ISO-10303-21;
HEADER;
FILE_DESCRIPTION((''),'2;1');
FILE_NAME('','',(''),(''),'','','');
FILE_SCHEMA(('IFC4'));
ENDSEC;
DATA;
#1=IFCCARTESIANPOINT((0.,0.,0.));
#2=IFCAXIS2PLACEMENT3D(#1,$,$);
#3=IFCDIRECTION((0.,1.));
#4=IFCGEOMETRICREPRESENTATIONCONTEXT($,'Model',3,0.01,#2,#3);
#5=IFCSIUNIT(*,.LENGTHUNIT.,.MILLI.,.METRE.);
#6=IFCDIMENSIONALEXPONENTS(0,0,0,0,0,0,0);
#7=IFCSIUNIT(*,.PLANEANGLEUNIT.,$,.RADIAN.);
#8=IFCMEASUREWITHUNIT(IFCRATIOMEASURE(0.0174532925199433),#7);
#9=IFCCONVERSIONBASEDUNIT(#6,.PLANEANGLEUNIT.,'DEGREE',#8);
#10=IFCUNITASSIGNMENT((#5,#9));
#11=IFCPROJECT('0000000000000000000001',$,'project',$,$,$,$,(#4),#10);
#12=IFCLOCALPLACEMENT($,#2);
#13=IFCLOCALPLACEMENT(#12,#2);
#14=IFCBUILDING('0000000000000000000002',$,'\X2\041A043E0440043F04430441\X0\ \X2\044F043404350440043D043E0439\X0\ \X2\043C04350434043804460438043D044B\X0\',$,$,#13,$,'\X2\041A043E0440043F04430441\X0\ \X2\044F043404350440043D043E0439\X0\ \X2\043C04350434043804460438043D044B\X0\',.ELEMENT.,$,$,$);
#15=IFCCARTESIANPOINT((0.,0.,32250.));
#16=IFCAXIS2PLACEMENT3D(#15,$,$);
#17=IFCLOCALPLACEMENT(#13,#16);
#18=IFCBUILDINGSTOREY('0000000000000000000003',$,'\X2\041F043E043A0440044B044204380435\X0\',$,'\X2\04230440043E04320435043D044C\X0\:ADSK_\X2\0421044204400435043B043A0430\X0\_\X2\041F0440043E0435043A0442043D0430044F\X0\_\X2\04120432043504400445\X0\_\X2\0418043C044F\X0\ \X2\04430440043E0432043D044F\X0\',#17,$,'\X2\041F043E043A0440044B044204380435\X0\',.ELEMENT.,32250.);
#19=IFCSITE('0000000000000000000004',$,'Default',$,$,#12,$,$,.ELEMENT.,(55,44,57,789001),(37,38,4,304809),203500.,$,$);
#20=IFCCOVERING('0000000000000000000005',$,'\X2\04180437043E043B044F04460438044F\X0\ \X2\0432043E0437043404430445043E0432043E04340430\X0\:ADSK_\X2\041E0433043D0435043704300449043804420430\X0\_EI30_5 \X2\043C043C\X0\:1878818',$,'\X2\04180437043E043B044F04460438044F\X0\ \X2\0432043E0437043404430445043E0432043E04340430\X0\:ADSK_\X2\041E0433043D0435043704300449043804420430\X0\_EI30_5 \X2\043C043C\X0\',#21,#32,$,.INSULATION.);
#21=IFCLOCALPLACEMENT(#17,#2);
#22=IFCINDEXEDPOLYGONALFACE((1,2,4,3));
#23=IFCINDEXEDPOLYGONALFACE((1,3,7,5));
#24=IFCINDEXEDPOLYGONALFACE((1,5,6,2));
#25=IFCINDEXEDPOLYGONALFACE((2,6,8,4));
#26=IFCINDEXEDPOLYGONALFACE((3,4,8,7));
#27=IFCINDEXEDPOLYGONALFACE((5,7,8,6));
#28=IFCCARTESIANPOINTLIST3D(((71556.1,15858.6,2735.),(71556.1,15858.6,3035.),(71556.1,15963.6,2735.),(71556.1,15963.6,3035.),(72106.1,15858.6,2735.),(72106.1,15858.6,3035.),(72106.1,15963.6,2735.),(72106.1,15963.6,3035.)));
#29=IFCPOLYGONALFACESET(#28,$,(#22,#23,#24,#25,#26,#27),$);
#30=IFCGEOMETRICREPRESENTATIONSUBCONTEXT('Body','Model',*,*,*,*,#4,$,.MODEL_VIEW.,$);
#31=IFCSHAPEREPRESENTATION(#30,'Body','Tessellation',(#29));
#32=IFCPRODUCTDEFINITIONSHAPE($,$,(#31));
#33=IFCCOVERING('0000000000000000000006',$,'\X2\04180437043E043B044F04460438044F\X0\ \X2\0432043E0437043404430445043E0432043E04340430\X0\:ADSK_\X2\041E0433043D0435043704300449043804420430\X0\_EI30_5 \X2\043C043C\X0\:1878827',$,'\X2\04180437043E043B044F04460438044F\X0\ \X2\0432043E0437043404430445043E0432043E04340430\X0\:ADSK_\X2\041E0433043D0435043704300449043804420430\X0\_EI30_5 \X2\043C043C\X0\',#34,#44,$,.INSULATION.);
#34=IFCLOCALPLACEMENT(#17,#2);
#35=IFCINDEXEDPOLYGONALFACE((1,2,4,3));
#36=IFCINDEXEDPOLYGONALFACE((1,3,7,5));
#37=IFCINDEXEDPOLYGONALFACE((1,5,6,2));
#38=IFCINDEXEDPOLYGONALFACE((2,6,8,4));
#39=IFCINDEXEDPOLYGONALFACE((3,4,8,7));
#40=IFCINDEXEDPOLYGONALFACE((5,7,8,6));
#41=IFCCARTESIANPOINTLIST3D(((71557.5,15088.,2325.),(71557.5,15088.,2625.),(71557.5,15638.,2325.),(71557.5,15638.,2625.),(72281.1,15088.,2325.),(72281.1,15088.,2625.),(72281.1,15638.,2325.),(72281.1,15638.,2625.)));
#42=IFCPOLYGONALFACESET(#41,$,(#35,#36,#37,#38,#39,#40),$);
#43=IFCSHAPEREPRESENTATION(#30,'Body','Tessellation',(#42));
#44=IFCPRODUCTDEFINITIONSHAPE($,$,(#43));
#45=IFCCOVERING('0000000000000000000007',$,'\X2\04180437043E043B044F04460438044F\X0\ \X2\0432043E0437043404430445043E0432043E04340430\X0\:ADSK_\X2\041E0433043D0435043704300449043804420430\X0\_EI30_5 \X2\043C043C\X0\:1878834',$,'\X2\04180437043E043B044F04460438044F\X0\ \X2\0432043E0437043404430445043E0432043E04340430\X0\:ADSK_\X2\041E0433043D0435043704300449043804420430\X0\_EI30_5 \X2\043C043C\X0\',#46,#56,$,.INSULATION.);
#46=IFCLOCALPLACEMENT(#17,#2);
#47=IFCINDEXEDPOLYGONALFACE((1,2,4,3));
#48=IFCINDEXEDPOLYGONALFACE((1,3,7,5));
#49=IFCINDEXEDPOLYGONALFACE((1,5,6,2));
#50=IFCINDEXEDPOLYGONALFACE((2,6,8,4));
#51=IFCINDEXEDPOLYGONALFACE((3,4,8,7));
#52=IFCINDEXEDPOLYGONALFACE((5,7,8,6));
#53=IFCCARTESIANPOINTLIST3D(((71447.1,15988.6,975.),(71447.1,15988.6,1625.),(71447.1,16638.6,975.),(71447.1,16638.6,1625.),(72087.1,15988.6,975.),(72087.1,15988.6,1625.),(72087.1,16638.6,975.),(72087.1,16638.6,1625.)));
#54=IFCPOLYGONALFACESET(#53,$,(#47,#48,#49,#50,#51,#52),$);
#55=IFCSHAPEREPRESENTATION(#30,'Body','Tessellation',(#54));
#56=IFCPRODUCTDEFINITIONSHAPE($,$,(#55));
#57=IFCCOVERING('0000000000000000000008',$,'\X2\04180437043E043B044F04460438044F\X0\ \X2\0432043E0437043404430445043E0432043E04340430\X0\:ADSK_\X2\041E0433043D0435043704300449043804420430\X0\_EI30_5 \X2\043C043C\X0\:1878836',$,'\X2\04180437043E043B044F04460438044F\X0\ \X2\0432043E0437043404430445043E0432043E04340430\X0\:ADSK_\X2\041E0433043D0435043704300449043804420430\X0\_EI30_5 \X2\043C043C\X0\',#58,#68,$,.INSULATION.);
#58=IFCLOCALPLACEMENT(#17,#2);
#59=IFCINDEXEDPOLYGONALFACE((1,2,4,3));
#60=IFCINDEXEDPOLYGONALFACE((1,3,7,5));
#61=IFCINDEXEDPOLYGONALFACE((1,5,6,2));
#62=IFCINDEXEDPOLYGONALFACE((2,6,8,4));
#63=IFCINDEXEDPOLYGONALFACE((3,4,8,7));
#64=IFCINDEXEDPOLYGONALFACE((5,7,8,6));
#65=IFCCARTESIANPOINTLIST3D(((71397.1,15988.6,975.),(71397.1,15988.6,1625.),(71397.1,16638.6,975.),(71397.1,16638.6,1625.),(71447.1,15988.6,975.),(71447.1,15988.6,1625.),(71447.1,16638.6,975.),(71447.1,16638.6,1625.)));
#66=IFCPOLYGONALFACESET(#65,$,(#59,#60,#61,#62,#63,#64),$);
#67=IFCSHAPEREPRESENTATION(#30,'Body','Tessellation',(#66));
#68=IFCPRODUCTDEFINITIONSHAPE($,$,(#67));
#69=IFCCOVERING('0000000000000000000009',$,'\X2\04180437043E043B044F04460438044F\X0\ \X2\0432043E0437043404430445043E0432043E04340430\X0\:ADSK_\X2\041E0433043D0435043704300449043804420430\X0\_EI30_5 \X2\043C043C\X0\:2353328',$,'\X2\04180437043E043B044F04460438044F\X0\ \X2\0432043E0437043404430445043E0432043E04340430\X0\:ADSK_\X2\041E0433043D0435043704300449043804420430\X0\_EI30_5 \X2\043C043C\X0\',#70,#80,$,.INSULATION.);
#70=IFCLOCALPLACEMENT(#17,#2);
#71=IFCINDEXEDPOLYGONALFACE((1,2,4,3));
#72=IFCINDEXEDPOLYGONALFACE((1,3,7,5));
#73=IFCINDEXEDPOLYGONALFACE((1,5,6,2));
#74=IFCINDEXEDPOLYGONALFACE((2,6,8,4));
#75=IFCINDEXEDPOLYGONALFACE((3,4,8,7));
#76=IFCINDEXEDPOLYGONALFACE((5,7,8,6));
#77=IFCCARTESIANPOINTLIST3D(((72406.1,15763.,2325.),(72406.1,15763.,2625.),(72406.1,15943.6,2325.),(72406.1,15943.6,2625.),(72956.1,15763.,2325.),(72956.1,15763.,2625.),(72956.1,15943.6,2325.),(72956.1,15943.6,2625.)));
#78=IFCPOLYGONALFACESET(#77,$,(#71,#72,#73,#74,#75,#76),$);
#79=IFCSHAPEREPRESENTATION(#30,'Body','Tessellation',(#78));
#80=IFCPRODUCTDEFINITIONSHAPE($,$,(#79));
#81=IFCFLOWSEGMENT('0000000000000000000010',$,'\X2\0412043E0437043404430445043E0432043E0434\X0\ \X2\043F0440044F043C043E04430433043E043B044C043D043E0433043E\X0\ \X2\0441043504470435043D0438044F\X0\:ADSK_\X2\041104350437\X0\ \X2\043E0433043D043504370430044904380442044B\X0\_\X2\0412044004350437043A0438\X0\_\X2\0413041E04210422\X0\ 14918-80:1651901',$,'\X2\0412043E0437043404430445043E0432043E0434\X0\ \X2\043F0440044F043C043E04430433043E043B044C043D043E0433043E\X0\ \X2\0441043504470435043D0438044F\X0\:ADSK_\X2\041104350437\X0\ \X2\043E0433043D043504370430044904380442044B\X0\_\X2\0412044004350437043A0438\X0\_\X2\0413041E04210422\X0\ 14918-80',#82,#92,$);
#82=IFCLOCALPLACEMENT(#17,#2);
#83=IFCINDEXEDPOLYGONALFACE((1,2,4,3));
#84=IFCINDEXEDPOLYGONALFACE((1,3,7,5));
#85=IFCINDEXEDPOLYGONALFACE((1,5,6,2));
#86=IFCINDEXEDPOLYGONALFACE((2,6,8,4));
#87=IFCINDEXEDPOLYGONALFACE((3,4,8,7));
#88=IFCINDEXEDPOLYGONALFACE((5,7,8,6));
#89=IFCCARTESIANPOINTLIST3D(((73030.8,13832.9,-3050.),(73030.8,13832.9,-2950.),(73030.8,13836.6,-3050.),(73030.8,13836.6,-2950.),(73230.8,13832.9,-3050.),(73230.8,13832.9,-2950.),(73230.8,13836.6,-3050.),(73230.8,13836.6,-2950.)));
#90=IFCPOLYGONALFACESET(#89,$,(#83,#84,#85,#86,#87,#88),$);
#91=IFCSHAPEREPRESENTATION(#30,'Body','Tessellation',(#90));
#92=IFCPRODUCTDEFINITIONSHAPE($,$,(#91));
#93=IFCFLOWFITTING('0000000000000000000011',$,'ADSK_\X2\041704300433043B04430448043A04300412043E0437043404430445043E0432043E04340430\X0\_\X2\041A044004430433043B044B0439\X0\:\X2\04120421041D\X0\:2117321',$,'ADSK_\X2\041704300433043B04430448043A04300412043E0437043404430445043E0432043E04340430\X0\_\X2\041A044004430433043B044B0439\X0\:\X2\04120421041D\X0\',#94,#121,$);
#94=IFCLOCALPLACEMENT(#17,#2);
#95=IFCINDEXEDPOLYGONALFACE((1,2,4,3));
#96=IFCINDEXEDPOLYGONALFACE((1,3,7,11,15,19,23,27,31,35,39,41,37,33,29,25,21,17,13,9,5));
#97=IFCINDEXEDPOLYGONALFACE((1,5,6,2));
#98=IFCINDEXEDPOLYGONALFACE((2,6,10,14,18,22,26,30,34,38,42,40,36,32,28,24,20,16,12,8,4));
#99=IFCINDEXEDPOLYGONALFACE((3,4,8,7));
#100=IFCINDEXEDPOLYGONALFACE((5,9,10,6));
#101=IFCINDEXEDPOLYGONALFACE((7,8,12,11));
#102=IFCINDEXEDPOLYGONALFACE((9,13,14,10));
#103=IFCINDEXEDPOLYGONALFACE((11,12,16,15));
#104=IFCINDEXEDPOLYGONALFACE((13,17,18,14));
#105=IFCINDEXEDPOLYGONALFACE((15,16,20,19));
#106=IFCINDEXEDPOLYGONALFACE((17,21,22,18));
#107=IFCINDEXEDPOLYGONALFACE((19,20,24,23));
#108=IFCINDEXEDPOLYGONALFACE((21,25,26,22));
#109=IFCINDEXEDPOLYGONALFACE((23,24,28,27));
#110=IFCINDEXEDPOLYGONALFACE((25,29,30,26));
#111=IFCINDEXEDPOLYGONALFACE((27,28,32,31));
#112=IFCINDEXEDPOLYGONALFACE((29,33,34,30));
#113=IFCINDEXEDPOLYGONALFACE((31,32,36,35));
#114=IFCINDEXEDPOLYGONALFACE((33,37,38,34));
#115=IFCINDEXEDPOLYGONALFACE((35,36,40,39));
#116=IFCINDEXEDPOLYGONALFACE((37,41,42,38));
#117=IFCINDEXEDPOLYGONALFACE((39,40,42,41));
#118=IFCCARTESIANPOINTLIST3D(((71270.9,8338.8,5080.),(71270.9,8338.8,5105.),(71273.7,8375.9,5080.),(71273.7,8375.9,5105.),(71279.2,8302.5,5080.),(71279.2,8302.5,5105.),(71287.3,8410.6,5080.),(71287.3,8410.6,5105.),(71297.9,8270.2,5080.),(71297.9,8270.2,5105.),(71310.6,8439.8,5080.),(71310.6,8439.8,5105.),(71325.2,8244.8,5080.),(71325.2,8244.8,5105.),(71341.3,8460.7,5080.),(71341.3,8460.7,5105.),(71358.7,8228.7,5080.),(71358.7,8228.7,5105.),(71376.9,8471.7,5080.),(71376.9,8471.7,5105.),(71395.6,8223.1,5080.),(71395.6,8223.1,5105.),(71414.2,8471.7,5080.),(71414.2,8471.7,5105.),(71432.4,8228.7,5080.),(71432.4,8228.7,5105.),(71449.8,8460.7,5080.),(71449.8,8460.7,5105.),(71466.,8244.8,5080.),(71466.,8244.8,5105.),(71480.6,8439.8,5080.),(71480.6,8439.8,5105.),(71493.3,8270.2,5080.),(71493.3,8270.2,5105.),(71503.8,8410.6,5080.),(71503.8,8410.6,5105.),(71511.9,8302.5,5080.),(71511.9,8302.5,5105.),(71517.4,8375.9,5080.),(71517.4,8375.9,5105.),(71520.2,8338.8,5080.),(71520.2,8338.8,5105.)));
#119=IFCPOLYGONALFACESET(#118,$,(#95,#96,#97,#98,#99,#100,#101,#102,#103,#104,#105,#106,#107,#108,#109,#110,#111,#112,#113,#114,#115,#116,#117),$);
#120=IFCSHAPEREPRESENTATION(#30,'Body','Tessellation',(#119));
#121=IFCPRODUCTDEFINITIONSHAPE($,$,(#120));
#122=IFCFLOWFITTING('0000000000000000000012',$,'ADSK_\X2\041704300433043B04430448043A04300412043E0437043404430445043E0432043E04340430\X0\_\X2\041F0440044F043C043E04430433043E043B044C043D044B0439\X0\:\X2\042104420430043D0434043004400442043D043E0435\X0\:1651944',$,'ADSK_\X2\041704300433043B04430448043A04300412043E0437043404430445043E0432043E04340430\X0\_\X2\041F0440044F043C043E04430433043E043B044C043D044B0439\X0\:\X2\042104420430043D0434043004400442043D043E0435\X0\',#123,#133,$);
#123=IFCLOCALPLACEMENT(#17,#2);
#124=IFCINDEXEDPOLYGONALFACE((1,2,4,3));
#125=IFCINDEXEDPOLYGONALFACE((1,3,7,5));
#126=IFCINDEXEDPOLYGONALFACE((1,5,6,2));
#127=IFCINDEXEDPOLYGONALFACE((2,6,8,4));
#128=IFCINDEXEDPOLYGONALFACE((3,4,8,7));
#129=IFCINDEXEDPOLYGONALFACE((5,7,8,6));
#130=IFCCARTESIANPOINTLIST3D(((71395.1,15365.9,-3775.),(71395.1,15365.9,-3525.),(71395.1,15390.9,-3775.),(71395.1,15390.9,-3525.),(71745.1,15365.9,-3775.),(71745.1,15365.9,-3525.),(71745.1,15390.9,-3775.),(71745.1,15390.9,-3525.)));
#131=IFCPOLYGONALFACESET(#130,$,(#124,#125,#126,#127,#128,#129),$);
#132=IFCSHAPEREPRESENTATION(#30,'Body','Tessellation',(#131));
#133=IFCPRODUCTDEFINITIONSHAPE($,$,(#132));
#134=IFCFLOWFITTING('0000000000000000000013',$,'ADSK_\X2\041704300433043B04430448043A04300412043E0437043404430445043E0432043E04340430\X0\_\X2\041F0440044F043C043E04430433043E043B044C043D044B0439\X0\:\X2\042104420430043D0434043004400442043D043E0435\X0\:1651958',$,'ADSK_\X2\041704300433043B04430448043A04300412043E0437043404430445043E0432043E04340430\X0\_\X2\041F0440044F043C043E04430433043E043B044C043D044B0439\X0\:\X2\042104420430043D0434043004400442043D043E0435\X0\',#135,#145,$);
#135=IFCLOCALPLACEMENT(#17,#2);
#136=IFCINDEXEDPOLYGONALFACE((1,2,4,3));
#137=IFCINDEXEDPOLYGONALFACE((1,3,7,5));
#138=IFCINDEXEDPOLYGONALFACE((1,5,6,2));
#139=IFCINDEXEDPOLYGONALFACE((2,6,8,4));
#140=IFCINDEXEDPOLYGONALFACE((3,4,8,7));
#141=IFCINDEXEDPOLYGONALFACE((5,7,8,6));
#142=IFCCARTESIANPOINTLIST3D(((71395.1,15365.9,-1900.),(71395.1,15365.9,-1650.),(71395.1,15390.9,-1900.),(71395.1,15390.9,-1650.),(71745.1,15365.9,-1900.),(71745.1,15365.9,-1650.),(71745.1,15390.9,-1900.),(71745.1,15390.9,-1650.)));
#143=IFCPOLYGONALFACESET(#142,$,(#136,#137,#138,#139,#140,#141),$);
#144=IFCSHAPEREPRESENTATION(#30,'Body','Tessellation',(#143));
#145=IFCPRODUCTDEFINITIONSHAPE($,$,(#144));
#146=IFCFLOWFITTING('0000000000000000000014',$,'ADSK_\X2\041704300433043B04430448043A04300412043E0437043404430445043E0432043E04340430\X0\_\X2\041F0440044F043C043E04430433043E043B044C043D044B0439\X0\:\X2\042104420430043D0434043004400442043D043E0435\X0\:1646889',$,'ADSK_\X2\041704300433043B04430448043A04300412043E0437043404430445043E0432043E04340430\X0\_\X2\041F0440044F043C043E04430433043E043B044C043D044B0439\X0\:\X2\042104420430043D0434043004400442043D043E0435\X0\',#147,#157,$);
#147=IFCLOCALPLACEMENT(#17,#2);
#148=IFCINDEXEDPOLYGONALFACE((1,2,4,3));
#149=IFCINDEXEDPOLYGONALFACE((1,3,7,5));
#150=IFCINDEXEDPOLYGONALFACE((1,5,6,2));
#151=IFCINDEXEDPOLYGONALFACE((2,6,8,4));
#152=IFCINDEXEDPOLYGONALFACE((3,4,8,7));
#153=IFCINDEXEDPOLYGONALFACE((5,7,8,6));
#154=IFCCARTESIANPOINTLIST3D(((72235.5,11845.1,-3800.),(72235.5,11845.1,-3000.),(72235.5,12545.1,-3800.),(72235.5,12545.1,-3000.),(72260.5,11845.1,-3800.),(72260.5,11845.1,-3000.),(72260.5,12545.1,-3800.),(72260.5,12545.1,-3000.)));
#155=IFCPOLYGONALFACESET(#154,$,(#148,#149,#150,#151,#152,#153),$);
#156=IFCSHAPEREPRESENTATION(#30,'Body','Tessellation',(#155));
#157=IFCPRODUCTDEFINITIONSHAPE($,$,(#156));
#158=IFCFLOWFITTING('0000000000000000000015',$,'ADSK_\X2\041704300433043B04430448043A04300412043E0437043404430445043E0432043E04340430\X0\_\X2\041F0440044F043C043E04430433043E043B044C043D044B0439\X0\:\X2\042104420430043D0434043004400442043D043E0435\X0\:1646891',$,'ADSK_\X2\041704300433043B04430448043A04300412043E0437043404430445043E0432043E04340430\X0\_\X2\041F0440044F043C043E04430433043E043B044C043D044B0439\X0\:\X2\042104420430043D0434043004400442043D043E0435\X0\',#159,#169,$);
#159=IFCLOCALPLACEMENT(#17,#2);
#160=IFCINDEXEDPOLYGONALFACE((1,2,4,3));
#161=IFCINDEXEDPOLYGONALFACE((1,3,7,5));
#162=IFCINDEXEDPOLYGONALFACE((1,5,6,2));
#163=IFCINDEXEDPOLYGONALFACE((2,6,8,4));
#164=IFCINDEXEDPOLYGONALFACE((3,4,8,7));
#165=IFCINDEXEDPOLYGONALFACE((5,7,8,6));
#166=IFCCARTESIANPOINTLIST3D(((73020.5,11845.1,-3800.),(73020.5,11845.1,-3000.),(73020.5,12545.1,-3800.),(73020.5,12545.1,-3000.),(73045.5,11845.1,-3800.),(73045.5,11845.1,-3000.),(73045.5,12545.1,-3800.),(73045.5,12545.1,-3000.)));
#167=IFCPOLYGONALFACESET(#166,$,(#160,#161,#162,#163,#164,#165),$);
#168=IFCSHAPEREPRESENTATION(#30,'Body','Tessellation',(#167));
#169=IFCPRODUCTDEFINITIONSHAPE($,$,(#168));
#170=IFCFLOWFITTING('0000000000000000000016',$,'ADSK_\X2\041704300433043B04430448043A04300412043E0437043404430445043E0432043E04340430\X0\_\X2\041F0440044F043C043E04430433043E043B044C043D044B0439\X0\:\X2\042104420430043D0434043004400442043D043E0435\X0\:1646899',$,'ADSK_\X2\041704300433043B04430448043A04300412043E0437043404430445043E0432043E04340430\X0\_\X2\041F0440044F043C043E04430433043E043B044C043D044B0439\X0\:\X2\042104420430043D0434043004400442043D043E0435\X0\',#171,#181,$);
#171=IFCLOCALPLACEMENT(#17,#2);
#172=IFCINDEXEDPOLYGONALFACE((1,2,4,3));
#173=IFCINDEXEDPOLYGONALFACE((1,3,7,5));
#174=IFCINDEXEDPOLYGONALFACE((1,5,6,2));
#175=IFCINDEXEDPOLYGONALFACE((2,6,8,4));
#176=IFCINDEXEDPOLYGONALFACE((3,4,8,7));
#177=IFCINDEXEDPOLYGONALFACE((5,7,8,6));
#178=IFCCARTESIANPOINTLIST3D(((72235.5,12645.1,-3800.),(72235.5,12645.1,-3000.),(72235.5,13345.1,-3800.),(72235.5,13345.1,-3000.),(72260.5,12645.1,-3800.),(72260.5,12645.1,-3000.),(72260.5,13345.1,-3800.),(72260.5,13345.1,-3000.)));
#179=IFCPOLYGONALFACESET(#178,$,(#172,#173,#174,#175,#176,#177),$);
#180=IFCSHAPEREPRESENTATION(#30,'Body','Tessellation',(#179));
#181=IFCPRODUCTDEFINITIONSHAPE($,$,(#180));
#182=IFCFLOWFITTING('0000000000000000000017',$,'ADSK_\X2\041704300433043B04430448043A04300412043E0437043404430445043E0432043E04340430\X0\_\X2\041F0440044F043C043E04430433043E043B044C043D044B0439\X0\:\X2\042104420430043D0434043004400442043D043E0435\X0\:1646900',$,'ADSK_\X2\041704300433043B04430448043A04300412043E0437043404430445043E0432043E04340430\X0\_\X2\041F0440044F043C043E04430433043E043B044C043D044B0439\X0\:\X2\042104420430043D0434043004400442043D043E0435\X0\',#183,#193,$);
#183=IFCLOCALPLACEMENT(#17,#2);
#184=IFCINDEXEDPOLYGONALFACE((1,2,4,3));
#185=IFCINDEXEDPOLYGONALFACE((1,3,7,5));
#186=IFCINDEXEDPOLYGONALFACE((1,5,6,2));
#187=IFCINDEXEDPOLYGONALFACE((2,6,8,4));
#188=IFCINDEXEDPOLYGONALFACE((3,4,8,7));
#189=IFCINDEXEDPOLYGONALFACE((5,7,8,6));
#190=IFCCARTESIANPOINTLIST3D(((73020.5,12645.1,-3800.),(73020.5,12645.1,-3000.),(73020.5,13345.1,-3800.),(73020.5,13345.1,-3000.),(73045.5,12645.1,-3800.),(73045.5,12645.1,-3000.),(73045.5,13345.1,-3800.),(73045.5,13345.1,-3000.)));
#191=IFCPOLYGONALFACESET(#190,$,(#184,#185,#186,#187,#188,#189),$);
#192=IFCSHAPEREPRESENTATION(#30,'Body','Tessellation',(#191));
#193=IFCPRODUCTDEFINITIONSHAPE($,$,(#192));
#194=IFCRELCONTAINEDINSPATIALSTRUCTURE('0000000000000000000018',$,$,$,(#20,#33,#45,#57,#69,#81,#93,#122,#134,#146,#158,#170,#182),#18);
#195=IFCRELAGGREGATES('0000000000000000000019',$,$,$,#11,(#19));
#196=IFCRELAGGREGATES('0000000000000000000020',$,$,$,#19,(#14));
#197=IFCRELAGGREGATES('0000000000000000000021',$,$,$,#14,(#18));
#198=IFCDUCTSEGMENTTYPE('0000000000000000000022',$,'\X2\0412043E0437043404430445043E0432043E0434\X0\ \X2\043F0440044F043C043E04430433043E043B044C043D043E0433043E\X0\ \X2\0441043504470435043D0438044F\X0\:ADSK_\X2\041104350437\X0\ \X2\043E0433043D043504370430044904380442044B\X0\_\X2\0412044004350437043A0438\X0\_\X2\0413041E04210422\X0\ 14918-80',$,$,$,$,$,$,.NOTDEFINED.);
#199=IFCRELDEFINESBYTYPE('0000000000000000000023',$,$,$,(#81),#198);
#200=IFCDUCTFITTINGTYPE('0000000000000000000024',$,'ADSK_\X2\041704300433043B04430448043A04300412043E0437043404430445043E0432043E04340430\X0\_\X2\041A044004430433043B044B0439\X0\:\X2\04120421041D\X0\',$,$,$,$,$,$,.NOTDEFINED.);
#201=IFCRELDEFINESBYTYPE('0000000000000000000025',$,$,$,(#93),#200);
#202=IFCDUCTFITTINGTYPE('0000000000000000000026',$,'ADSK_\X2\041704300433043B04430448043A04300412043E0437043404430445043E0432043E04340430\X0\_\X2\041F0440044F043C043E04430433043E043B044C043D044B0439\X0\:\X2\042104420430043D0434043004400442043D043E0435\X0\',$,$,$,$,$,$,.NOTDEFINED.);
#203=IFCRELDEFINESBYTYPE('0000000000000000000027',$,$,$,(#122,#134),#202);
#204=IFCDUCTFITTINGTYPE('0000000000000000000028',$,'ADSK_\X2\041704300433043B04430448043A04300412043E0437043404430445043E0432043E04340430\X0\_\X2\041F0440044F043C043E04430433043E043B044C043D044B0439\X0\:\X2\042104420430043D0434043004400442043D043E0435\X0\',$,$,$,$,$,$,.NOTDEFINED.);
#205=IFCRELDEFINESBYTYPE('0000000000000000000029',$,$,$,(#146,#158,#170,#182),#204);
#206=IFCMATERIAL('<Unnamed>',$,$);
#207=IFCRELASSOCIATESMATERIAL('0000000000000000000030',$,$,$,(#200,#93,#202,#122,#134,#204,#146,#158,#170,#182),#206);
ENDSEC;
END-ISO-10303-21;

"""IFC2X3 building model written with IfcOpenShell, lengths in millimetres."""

from ifc_helpers import new_model, entity, si_unit, converted_unit, direction, frame, origin, origin_2d_with_axis, place, context, subcontext, project, spatial, rectangle, circle, extrude, source, transform, mapped, material, type_object, type_shapes, element, save


model = new_model("IFC2X3")

# Units and contexts
model_context = context("Model", 3, precision=0.01, world=origin(), true_north=direction((0.0, 1.0)))
body_context = subcontext(model_context, "Body", "Model", "MODEL_VIEW")
ifc_project = project(units=[si_unit("LENGTHUNIT", "METRE", prefix="MILLI"), converted_unit("PLANEANGLEUNIT", "DEGREE", entity("IfcRatioMeasure", 0.0174532925199433), si_unit("PLANEANGLEUNIT", "RADIAN"), dimensions=[0, 0, 0, 0, 0, 0, 0])], contexts=[model_context])

# Site, building, storey
site_placement = place(None, origin())
site = spatial("IfcSite", under=ifc_project, at=site_placement, Name="Default", CompositionType="ELEMENT", RefLatitude=(55, 44, 57, 789001), RefLongitude=(37, 38, 4, 304809), RefElevation=203500.0)
building_placement = place(site_placement, origin())
building = spatial("IfcBuilding", under=site, at=building_placement, Name="Корпус ядерной медицины", LongName="Корпус ядерной медицины", CompositionType="ELEMENT")
storey_placement = place(building_placement, frame((0.0, 0.0, 32250.0)))
storey = spatial("IfcBuildingStorey", under=building, at=storey_placement, Name="Покрытие", ObjectType="Уровень:ADSK_Стрелка_Проектная_Вверх_Имя уровня", LongName="Покрытие", CompositionType="ELEMENT", Elevation=32250.0)

# Coverings
covering_1_placement = place(storey_placement, frame((71556.1, 15858.6, 2735.0)))
element("IfcCovering", 1, at=covering_1_placement, inside=storey, Name="Изоляция воздуховода:ADSK_Огнезащита_EI30_5 мм:1878818", ObjectType="Изоляция воздуховода:ADSK_Огнезащита_EI30_5 мм", PredefinedType="INSULATION", context=body_context, shape_type="SweptSolid", body=[
    extrude(rectangle(XDim=105.0, YDim=550.0, at=origin_2d_with_axis()), frame((275.0, 52.5, 0.0), z_axis=(0.0, 0.0, 1.0), x_axis=(0.0, 1.0, 0.0)), (0.0, 0.0, 1.0), 300.0),
])
covering_2_placement = place(storey_placement, frame((71557.5, 15088.0, 2325.0)))
element("IfcCovering", 2, at=covering_2_placement, inside=storey, Name="Изоляция воздуховода:ADSK_Огнезащита_EI30_5 мм:1878827", ObjectType="Изоляция воздуховода:ADSK_Огнезащита_EI30_5 мм", PredefinedType="INSULATION", context=body_context, shape_type="SweptSolid", body=[
    extrude(rectangle(XDim=723.6, YDim=550.0, at=origin_2d_with_axis()), frame((361.8, 275.0, 0.0), z_axis=(0.0, 0.0, 1.0), x_axis=(-1.0, 0.0, 0.0)), (0.0, 0.0, 1.0), 300.0),
])
covering_3_placement = place(storey_placement, frame((71447.1, 15988.6, 975.0)))
element("IfcCovering", 3, at=covering_3_placement, inside=storey, Name="Изоляция воздуховода:ADSK_Огнезащита_EI30_5 мм:1878834", ObjectType="Изоляция воздуховода:ADSK_Огнезащита_EI30_5 мм", PredefinedType="INSULATION", context=body_context, shape_type="SweptSolid", body=[
    extrude(rectangle(XDim=640.0, YDim=650.0, at=origin_2d_with_axis()), frame((320.0, 325.0, 0.0)), (0.0, 0.0, 1.0), 650.0),
])
covering_4_placement = place(storey_placement, frame((71397.1, 15988.6, 975.0)))
element("IfcCovering", 4, at=covering_4_placement, inside=storey, Name="Изоляция воздуховода:ADSK_Огнезащита_EI30_5 мм:1878836", ObjectType="Изоляция воздуховода:ADSK_Огнезащита_EI30_5 мм", PredefinedType="INSULATION", context=body_context, shape_type="SweptSolid", body=[
    extrude(rectangle(XDim=50.0, YDim=650.0, at=origin_2d_with_axis()), frame((25.0, 325.0, 0.0)), (0.0, 0.0, 1.0), 650.0),
])
covering_5_placement = place(storey_placement, frame((72406.1, 15763.0, 2325.0)))
element("IfcCovering", 5, at=covering_5_placement, inside=storey, Name="Изоляция воздуховода:ADSK_Огнезащита_EI30_5 мм:2353328", ObjectType="Изоляция воздуховода:ADSK_Огнезащита_EI30_5 мм", PredefinedType="INSULATION", context=body_context, shape_type="SweptSolid", body=[
    extrude(rectangle(XDim=180.6, YDim=550.0, at=origin_2d_with_axis()), frame((275.0, 90.3, 0.0), z_axis=(0.0, 0.0, 1.0), x_axis=(0.0, 1.0, 0.0)), (0.0, 0.0, 1.0), 300.0),
])

# Flow segment
duct_segment_type = type_object("IfcDuctSegmentType", Name="Воздуховод прямоугольного сечения:ADSK_Без огнезащиты_Врезки_ГОСТ 14918-80", PredefinedType="NOTDEFINED")
flow_segment_placement = place(storey_placement, frame((73030.8, 13832.9, -3050.0)))
element("IfcFlowSegment", 6, at=flow_segment_placement, inside=storey, type_object=duct_segment_type, Name="Воздуховод прямоугольного сечения:ADSK_Без огнезащиты_Врезки_ГОСТ 14918-80:1651901", ObjectType="Воздуховод прямоугольного сечения:ADSK_Без огнезащиты_Врезки_ГОСТ 14918-80", context=body_context, shape_type="SweptSolid", body=[
    extrude(rectangle(XDim=3.8, YDim=200.0, at=origin_2d_with_axis()), frame((100.0, 1.9, 0.0), z_axis=(0.0, 0.0, 1.0), x_axis=(0.0, -1.0, 0.0)), (0.0, 0.0, 1.0), 100.0),
])

# Flow fittings
ifc_material = material(Name="<Unnamed>")
duct_fitting_type_1 = type_object("IfcDuctFittingType", Name="ADSK_ЗаглушкаВоздуховода_Круглый:ВСН", PredefinedType="NOTDEFINED", material=ifc_material)
shared_shape_1 = source(origin(), body_context, "Body", "SweptSolid", [
    extrude(circle(Radius=125.0, at=origin_2d_with_axis()), frame((0.0, 0.0, 0.0), z_axis=(1.0, 0.0, 0.0), x_axis=(0.0, 1.0, 0.0)), (0.0, 0.0, 1.0), 25.0),
])
type_shapes(duct_fitting_type_1, [shared_shape_1])
flow_fitting_1_placement = place(storey_placement, frame((71395.6, 8348.1, 5080.0), z_axis=(1.0, 0.0, 0.0), x_axis=(0.0, 0.0, 1.0)))
element("IfcFlowFitting", 7, at=flow_fitting_1_placement, inside=storey, type_object=duct_fitting_type_1, material=ifc_material, Name="ADSK_ЗаглушкаВоздуховода_Круглый:ВСН:2117321", ObjectType="ADSK_ЗаглушкаВоздуховода_Круглый:ВСН", context=body_context, shape_type="MappedRepresentation", body=[
    mapped(shared_shape_1, transform((0.0, 0.0, 0.0), scale=1.0)),
])
duct_fitting_type_2 = type_object("IfcDuctFittingType", Name="ADSK_ЗаглушкаВоздуховода_Прямоугольный:Стандартное", PredefinedType="NOTDEFINED", material=ifc_material)
shared_shape_2 = source(origin(), body_context, "Body", "SweptSolid", [
    extrude(rectangle(XDim=25.0, YDim=350.0, at=origin_2d_with_axis()), frame((12.5, 0.0, -125.0)), (0.0, 0.0, 1.0), 250.0),
])
type_shapes(duct_fitting_type_2, [shared_shape_2])
for number, where, z_axis, x_axis, name in (
    (8, (71570.1, 15390.9, -3650.0), (0.0, 0.0, 1.0), (0.0, -1.0, 0.0), "ADSK_ЗаглушкаВоздуховода_Прямоугольный:Стандартное:1651944"),
    (9, (71570.1, 15390.9, -1775.0), (0.0, 0.0, 1.0), (0.0, -1.0, 0.0), "ADSK_ЗаглушкаВоздуховода_Прямоугольный:Стандартное:1651958"),
):
    element("IfcFlowFitting", number, at=place(storey_placement, frame(where, z_axis=z_axis, x_axis=x_axis)), inside=storey, type_object=duct_fitting_type_2, material=ifc_material, Name=name, ObjectType="ADSK_ЗаглушкаВоздуховода_Прямоугольный:Стандартное", context=body_context, shape_type="MappedRepresentation", body=[
        mapped(shared_shape_2, transform((0.0, 0.0, 0.0), scale=1.0)),
    ])
duct_fitting_type_3 = type_object("IfcDuctFittingType", Name="ADSK_ЗаглушкаВоздуховода_Прямоугольный:Стандартное", PredefinedType="NOTDEFINED", material=ifc_material)
shared_shape_3 = source(origin(), body_context, "Body", "SweptSolid", [
    extrude(rectangle(XDim=25.0, YDim=700.0, at=origin_2d_with_axis()), frame((12.5, 0.0, -400.0)), (0.0, 0.0, 1.0), 800.0),
])
type_shapes(duct_fitting_type_3, [shared_shape_3])
flow_fitting_2_placement = place(storey_placement, frame((72260.5, 12195.1, -3400.0), z_axis=(0.0, 0.0, 1.0), x_axis=(-1.0, 0.0, 0.0)))
element("IfcFlowFitting", 10, at=flow_fitting_2_placement, inside=storey, type_object=duct_fitting_type_3, material=ifc_material, Name="ADSK_ЗаглушкаВоздуховода_Прямоугольный:Стандартное:1646889", ObjectType="ADSK_ЗаглушкаВоздуховода_Прямоугольный:Стандартное", context=body_context, shape_type="MappedRepresentation", body=[
    mapped(shared_shape_3, transform((0.0, 0.0, 0.0), scale=1.0)),
])
flow_fitting_3_placement = place(storey_placement, frame((73020.5, 12195.1, -3400.0)))
element("IfcFlowFitting", 11, at=flow_fitting_3_placement, inside=storey, type_object=duct_fitting_type_3, material=ifc_material, Name="ADSK_ЗаглушкаВоздуховода_Прямоугольный:Стандартное:1646891", ObjectType="ADSK_ЗаглушкаВоздуховода_Прямоугольный:Стандартное", context=body_context, shape_type="MappedRepresentation", body=[
    mapped(shared_shape_3, transform((0.0, 0.0, 0.0), scale=1.0)),
])
flow_fitting_4_placement = place(storey_placement, frame((72260.5, 12995.1, -3400.0), z_axis=(0.0, 0.0, 1.0), x_axis=(-1.0, 0.0, 0.0)))
element("IfcFlowFitting", 12, at=flow_fitting_4_placement, inside=storey, type_object=duct_fitting_type_3, material=ifc_material, Name="ADSK_ЗаглушкаВоздуховода_Прямоугольный:Стандартное:1646899", ObjectType="ADSK_ЗаглушкаВоздуховода_Прямоугольный:Стандартное", context=body_context, shape_type="MappedRepresentation", body=[
    mapped(shared_shape_3, transform((0.0, 0.0, 0.0), scale=1.0)),
])
flow_fitting_5_placement = place(storey_placement, frame((73020.5, 12995.1, -3400.0)))
element("IfcFlowFitting", 13, at=flow_fitting_5_placement, inside=storey, type_object=duct_fitting_type_3, material=ifc_material, Name="ADSK_ЗаглушкаВоздуховода_Прямоугольный:Стандартное:1646900", ObjectType="ADSK_ЗаглушкаВоздуховода_Прямоугольный:Стандартное", context=body_context, shape_type="MappedRepresentation", body=[
    mapped(shared_shape_3, transform((0.0, 0.0, 0.0), scale=1.0)),
])

save(model, "model.ifc")
